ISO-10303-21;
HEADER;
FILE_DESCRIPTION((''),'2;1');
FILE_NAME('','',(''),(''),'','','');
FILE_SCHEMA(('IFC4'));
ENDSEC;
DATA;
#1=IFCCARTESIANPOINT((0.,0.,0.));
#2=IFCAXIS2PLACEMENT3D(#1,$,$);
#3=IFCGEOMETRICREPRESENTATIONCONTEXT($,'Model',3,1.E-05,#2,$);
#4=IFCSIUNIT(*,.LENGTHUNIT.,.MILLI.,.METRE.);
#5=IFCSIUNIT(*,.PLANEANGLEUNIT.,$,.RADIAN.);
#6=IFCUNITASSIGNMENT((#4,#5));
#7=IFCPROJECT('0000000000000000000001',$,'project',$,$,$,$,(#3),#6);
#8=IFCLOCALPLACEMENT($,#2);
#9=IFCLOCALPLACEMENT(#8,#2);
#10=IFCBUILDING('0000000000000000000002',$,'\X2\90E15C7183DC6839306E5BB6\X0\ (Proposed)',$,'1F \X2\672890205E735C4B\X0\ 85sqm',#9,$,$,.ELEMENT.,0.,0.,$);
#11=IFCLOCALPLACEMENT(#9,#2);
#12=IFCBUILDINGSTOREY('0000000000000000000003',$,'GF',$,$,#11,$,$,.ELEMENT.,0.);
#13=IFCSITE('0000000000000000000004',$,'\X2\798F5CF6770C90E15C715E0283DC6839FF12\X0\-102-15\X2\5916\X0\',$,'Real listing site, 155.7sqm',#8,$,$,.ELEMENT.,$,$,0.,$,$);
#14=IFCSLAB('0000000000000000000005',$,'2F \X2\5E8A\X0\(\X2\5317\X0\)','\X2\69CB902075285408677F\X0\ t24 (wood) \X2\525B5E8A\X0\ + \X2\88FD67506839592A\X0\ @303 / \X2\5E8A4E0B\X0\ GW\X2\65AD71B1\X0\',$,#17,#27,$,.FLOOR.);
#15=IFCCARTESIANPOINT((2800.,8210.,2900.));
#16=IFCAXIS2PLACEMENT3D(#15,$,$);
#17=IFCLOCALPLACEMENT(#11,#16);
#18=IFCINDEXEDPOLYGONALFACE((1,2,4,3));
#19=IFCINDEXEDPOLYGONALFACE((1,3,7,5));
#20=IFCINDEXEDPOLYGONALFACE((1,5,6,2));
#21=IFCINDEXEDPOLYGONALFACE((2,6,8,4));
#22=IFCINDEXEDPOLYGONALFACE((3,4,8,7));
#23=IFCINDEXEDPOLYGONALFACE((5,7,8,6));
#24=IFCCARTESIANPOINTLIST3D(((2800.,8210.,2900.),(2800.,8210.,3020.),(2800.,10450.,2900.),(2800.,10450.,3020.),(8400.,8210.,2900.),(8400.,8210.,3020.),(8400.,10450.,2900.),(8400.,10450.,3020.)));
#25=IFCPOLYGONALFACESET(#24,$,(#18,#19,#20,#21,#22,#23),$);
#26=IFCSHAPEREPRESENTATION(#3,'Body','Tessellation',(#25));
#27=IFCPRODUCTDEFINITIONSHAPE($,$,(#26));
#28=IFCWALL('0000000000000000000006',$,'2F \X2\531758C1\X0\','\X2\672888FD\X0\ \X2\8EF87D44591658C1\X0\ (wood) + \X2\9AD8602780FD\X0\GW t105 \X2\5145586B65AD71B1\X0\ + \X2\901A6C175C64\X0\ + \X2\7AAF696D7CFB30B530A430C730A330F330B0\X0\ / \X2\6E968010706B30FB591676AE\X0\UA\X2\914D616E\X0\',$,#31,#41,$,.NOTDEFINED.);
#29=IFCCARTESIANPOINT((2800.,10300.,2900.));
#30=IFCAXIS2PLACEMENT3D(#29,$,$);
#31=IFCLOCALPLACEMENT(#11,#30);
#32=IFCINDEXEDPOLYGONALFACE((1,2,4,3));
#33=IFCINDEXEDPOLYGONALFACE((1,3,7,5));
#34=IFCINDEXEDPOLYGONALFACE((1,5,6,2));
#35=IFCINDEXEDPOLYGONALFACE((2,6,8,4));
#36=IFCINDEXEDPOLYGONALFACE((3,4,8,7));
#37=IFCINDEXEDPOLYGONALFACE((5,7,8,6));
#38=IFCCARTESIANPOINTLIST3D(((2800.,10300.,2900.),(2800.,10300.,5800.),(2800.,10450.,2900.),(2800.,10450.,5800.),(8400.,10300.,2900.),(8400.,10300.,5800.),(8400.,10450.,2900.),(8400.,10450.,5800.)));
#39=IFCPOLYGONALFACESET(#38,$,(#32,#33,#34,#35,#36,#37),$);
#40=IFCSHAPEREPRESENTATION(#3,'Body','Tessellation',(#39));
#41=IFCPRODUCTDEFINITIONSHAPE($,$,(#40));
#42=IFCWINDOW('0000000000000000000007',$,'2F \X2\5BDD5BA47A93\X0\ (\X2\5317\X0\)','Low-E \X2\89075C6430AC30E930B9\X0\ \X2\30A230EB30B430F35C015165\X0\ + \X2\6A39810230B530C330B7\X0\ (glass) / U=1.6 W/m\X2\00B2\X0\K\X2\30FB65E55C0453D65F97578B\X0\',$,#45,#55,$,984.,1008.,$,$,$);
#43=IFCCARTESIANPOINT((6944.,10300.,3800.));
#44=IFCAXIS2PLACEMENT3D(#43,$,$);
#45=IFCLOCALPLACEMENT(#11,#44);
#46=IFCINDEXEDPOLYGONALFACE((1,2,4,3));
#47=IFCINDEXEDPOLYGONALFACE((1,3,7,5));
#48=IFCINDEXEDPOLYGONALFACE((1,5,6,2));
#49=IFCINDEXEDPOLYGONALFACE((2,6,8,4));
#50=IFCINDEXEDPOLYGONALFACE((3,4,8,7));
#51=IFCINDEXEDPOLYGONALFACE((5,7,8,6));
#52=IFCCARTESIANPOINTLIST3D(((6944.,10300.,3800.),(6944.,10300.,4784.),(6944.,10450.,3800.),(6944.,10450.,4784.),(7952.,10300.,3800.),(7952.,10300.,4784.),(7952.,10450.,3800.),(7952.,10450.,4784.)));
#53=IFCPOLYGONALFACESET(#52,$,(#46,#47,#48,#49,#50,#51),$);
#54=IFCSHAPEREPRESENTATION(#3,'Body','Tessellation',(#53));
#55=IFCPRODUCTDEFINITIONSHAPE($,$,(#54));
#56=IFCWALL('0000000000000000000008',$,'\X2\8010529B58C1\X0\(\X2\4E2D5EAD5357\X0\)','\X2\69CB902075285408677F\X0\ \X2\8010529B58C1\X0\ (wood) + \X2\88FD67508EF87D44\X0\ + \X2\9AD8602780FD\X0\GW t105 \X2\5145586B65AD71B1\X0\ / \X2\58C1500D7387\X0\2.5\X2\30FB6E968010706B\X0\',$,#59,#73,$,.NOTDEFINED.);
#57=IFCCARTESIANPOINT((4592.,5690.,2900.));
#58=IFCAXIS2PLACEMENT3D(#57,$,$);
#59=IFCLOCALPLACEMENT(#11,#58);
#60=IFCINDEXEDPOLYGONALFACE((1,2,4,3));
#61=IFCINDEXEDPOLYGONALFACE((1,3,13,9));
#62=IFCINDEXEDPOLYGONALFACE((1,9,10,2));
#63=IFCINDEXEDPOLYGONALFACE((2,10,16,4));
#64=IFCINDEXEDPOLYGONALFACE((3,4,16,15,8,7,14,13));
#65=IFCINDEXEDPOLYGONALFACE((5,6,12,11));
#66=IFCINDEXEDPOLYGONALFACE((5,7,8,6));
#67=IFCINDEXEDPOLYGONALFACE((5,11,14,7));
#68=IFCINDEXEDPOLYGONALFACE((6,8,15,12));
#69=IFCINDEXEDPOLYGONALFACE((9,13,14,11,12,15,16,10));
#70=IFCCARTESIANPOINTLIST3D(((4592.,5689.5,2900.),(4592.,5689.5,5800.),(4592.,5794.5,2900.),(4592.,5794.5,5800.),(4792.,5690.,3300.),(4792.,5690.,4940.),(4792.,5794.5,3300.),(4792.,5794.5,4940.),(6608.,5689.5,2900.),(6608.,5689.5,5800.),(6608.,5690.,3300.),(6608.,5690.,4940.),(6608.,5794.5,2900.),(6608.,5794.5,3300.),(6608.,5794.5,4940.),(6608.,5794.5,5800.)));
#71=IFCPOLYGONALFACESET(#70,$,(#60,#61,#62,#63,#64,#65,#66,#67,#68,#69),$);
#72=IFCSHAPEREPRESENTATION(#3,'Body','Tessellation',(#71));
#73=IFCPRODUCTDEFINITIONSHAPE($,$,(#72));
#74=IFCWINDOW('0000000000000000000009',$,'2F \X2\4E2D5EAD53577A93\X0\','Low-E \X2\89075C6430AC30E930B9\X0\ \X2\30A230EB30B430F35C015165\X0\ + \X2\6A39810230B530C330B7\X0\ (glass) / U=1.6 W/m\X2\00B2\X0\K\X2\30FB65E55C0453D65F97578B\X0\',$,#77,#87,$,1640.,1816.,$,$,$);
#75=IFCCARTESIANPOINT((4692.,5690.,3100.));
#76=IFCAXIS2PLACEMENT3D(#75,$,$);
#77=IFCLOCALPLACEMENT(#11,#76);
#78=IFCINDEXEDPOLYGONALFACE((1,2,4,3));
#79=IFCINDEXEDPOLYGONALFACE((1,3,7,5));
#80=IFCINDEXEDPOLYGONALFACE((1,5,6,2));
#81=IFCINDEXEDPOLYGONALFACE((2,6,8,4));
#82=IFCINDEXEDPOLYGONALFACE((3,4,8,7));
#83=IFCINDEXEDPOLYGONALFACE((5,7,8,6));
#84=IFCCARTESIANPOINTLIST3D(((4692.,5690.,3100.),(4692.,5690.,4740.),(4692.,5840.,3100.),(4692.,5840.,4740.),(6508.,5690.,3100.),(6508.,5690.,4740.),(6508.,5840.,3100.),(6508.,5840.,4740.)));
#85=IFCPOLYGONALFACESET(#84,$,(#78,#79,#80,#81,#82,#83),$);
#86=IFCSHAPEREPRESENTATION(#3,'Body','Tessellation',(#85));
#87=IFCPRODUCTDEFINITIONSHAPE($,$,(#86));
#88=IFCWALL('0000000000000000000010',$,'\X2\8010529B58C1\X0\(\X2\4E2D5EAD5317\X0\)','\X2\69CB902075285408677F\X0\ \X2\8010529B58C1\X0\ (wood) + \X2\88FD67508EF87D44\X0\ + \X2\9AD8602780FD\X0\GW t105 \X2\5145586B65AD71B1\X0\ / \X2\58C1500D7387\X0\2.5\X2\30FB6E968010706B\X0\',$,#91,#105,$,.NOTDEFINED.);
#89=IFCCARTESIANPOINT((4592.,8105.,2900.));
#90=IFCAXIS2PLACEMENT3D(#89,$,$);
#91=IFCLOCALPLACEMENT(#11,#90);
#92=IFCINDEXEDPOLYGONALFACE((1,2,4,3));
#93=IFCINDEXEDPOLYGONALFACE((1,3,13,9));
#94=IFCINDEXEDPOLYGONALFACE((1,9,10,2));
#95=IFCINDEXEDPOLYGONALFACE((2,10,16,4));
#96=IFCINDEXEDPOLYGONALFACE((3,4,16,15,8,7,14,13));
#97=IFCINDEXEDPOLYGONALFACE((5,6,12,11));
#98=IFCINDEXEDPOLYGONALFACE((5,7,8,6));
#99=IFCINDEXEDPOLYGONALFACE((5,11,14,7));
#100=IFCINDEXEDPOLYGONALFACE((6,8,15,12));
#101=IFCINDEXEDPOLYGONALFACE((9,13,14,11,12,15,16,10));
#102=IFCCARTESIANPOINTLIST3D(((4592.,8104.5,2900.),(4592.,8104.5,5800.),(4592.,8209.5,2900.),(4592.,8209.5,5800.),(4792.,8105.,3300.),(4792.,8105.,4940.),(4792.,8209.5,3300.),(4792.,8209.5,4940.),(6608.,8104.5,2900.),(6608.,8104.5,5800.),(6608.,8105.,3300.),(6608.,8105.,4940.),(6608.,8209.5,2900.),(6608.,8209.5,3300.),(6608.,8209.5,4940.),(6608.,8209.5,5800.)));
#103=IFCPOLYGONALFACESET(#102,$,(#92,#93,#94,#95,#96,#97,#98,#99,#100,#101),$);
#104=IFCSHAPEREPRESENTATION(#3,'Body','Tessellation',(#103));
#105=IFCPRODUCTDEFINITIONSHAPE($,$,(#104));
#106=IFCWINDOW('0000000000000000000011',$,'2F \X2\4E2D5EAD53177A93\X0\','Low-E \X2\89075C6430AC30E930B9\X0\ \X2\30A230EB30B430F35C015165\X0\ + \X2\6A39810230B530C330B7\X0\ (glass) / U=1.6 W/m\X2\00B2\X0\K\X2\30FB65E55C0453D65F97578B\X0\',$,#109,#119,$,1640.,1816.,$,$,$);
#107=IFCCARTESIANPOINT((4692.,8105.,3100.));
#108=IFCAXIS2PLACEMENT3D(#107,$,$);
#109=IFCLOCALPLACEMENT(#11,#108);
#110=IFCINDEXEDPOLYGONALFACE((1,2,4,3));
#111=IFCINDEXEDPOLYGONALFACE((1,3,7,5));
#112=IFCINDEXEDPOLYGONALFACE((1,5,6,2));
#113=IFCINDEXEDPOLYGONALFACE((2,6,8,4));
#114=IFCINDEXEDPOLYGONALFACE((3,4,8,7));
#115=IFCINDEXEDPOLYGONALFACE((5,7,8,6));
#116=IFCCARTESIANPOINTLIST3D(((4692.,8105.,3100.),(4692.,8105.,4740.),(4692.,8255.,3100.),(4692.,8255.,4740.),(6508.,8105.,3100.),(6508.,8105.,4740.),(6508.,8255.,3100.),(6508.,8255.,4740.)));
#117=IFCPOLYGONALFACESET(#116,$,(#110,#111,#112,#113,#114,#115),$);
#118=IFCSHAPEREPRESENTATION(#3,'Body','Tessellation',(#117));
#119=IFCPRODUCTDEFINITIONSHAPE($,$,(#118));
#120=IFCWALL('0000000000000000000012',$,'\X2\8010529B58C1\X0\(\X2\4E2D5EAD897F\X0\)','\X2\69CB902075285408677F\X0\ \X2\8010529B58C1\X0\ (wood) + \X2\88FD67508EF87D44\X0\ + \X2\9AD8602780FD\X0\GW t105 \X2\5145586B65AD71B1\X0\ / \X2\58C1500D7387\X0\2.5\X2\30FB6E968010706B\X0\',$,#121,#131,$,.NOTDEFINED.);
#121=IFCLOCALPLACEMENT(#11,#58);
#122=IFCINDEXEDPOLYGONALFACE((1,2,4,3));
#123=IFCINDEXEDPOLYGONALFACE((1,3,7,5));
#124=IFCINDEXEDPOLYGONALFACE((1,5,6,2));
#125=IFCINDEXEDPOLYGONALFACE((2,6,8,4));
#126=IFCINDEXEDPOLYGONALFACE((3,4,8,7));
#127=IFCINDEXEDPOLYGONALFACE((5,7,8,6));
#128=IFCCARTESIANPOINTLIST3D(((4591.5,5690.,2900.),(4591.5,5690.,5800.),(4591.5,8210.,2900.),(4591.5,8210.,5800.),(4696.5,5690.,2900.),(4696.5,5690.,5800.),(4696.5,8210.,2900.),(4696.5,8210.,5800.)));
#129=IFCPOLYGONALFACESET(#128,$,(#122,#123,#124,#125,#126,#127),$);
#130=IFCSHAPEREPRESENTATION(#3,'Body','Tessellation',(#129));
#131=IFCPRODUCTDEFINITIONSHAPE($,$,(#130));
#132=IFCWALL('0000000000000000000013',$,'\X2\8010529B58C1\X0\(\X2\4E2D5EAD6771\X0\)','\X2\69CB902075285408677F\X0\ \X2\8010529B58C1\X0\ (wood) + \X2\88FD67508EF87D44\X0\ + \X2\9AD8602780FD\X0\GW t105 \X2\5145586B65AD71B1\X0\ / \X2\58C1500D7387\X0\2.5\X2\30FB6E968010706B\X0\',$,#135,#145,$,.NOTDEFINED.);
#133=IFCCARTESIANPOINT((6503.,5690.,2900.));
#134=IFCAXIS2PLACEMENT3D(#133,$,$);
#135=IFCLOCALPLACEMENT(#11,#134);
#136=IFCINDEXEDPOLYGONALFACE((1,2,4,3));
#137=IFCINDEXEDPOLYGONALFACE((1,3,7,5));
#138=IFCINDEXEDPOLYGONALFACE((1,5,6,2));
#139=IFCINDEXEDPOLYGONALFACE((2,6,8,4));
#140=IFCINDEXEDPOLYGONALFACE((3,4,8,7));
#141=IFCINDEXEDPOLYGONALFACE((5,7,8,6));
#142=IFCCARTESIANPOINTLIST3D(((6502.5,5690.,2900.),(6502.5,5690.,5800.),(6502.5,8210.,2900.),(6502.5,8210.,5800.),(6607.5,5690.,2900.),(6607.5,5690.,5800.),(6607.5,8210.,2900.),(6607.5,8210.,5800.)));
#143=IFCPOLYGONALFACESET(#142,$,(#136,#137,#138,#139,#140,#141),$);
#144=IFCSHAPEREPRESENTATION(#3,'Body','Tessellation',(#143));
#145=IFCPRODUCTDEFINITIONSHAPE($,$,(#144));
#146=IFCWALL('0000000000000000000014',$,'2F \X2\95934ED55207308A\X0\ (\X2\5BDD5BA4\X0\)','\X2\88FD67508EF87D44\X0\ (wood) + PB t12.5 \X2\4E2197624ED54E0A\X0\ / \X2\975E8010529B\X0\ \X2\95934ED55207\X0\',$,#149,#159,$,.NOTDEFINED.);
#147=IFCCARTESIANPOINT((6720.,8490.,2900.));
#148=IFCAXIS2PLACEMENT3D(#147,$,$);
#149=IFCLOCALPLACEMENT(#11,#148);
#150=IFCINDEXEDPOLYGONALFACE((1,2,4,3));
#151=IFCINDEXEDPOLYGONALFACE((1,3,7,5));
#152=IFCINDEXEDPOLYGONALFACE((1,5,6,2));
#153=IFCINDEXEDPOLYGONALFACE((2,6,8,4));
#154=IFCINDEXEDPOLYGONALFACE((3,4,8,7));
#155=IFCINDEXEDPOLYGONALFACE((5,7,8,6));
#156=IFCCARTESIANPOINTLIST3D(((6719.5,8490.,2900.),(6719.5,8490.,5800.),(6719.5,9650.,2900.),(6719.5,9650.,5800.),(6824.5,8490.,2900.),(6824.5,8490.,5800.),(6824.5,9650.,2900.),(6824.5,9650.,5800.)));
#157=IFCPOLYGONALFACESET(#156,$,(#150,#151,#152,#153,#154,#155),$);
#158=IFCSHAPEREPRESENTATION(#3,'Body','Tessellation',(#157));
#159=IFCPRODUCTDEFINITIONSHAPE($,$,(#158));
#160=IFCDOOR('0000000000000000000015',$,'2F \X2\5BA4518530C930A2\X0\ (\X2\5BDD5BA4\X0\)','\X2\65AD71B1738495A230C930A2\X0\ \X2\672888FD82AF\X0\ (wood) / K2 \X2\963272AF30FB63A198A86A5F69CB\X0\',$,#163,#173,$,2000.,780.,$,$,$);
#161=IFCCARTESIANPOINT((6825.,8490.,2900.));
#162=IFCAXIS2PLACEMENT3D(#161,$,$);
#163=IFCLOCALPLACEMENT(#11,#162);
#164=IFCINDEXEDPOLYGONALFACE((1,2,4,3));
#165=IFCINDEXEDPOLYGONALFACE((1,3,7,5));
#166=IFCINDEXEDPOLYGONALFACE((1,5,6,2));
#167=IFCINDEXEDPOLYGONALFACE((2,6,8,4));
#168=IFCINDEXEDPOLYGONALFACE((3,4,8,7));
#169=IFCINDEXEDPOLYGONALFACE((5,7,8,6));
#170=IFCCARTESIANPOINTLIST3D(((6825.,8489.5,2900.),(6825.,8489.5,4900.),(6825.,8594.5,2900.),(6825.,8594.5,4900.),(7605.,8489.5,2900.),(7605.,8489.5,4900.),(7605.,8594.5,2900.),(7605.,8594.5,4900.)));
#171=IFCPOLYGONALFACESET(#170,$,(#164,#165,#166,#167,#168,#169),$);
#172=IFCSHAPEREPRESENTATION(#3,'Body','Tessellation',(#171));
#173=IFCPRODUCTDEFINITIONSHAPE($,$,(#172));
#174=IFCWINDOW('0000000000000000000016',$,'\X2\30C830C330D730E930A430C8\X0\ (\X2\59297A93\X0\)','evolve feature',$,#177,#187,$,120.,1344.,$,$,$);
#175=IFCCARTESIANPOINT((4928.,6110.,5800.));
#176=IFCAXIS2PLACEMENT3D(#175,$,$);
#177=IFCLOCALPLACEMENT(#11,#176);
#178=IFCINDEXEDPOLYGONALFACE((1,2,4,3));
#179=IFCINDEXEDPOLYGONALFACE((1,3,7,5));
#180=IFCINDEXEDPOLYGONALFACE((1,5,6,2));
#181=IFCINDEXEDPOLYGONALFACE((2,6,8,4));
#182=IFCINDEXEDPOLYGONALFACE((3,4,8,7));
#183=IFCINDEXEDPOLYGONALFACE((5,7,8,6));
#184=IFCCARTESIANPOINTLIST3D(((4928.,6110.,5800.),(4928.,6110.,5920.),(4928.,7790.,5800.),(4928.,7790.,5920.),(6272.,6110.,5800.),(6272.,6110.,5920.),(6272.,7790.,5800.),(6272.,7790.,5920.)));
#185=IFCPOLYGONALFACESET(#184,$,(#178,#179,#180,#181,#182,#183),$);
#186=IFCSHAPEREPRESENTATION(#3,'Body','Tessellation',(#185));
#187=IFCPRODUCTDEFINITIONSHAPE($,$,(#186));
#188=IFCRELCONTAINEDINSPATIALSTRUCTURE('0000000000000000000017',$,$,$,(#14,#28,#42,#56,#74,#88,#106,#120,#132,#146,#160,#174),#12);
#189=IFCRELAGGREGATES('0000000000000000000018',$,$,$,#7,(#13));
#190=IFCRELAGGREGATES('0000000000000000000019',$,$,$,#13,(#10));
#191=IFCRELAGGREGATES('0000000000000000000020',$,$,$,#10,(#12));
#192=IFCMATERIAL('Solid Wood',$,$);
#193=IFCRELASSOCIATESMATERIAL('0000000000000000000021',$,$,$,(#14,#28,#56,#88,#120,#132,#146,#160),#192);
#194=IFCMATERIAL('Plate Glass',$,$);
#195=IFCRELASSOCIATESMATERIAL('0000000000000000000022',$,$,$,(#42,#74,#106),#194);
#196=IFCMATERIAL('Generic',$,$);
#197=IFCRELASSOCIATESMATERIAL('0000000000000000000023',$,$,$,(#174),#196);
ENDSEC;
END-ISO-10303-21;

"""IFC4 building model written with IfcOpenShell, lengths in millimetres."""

from ifc_helpers import new_model, si_unit, frame, frame_2d, origin, place, context, project, spatial, rectangle, extrude, material, element, fill, save


model = new_model("IFC4")

# Units and contexts
model_context = context("Model", 3, precision=1e-05, world=origin())
ifc_project = project(units=[si_unit("LENGTHUNIT", "METRE", prefix="MILLI"), si_unit("PLANEANGLEUNIT", "RADIAN")], contexts=[model_context])

# Site, building, storey
site_placement = place(None, origin())
site = spatial("IfcSite", under=ifc_project, at=site_placement, Name="福島県郡山市菜根２-102-15外", ObjectType="Real listing site, 155.7sqm", CompositionType="ELEMENT", RefElevation=0.0)
building_placement = place(site_placement, origin())
building = spatial("IfcBuilding", under=site, at=building_placement, Name="郡山菜根の家 (Proposed)", ObjectType="1F 木造平屋 85sqm", CompositionType="ELEMENT", ElevationOfRefHeight=0.0, ElevationOfTerrain=0.0)
storey_placement = place(building_placement, origin())
storey = spatial("IfcBuildingStorey", under=building, at=storey_placement, Name="GF", CompositionType="ELEMENT", Elevation=0.0)

# Slab
ifc_material_1 = material(Name="Solid Wood")
slab_placement = place(storey_placement, frame((2800.0, 8210.0, 2900.0)))
element("IfcSlab", 1, at=slab_placement, inside=storey, material=ifc_material_1, Name="2F 床(北)", Description="構造用合板 t24 (wood) 剛床 + 製材根太 @303 / 床下 GW断熱", PredefinedType="FLOOR", context=model_context, shape_type="SweptSolid", body=[
    extrude(rectangle(XDim=5600.0, YDim=2240.0, at=frame_2d((2800.0, 1120.0))), frame((2800.0, 8210.0, 2900.0)), (0.0, 0.0, 1.0), 120.0),
])

# Walls, openings, windows
wall_1_placement = place(storey_placement, frame((2800.0, 10300.0, 2900.0)))
wall_1 = element("IfcWall", 2, at=wall_1_placement, inside=storey, material=ifc_material_1, Name="2F 北壁", Description="木製 軸組外壁 (wood) + 高性能GW t105 充填断熱 + 通気層 + 窯業系サイディング / 準耐火・外皮UA配慮", PredefinedType="NOTDEFINED", context=model_context, shape_type="SweptSolid", body=[
    extrude(rectangle(XDim=5600.0, YDim=150.0, at=frame_2d((2800.0, 75.0))), frame((2800.0, 10300.0, 2900.0)), (0.0, 0.0, 1.0), 2900.0),
])
opening_1_placement = place(storey_placement, frame((6944.0, 10300.0, 3800.0)))
opening_1 = element("IfcOpeningElement", 3, at=opening_1_placement, cuts=wall_1, PredefinedType="NOTDEFINED", context=model_context, shape_type="SweptSolid", body=[
    extrude(rectangle(XDim=1008.0, YDim=150.0, at=frame_2d((504.0, 75.0))), frame((6944.0, 10300.0, 3800.0)), (0.0, 0.0, 1.0), 984.0),
])
ifc_material_2 = material(Name="Plate Glass")
window_1_placement = place(storey_placement, frame((6944.0, 10300.0, 3800.0)))
window_1 = element("IfcWindow", 4, at=window_1_placement, inside=storey, material=ifc_material_2, Name="2F 寝室窓 (北)", Description="Low-E 複層ガラス アルゴン封入 + 樹脂サッシ (glass) / U=1.6 W/m²K・日射取得型", OverallHeight=984.0, OverallWidth=1008.0, context=model_context, shape_type="SweptSolid", body=[
    extrude(rectangle(XDim=1008.0, YDim=150.0, at=frame_2d((504.0, 75.0))), frame((6944.0, 10300.0, 3800.0)), (0.0, 0.0, 1.0), 984.0),
])
fill(opening_1, window_1)
wall_2_placement = place(storey_placement, frame((4592.0, 5690.0, 2900.0)))
wall_2 = element("IfcWall", 5, at=wall_2_placement, inside=storey, material=ifc_material_1, Name="耐力壁(中庭南)", Description="構造用合板 耐力壁 (wood) + 製材軸組 + 高性能GW t105 充填断熱 / 壁倍率2.5・準耐火", PredefinedType="NOTDEFINED", context=model_context, shape_type="SweptSolid", body=[
    extrude(rectangle(XDim=2016.0, YDim=105.0, at=frame_2d((1008.0, 52.0))), frame((4592.0, 5690.0, 2900.0)), (0.0, 0.0, 1.0), 2900.0),
])
opening_2_placement = place(storey_placement, frame((4692.0, 5690.0, 3100.0)))
opening_2 = element("IfcOpeningElement", 6, at=opening_2_placement, cuts=wall_2, PredefinedType="NOTDEFINED", context=model_context, shape_type="SweptSolid", body=[
    extrude(rectangle(XDim=1816.0, YDim=150.0, at=frame_2d((908.0, 75.0))), frame((4692.0, 5690.0, 3100.0)), (0.0, 0.0, 1.0), 1640.0),
])
window_2_placement = place(storey_placement, frame((4692.0, 5690.0, 3100.0)))
window_2 = element("IfcWindow", 7, at=window_2_placement, inside=storey, material=ifc_material_2, Name="2F 中庭南窓", Description="Low-E 複層ガラス アルゴン封入 + 樹脂サッシ (glass) / U=1.6 W/m²K・日射取得型", OverallHeight=1640.0, OverallWidth=1816.0, context=model_context, shape_type="SweptSolid", body=[
    extrude(rectangle(XDim=1816.0, YDim=150.0, at=frame_2d((908.0, 75.0))), frame((4692.0, 5690.0, 3100.0)), (0.0, 0.0, 1.0), 1640.0),
])
fill(opening_2, window_2)
wall_3_placement = place(storey_placement, frame((4592.0, 8105.0, 2900.0)))
wall_3 = element("IfcWall", 8, at=wall_3_placement, inside=storey, material=ifc_material_1, Name="耐力壁(中庭北)", Description="構造用合板 耐力壁 (wood) + 製材軸組 + 高性能GW t105 充填断熱 / 壁倍率2.5・準耐火", PredefinedType="NOTDEFINED", context=model_context, shape_type="SweptSolid", body=[
    extrude(rectangle(XDim=2016.0, YDim=105.0, at=frame_2d((1008.0, 52.0))), frame((4592.0, 8105.0, 2900.0)), (0.0, 0.0, 1.0), 2900.0),
])
opening_3_placement = place(storey_placement, frame((4692.0, 8105.0, 3100.0)))
opening_3 = element("IfcOpeningElement", 9, at=opening_3_placement, cuts=wall_3, PredefinedType="NOTDEFINED", context=model_context, shape_type="SweptSolid", body=[
    extrude(rectangle(XDim=1816.0, YDim=150.0, at=frame_2d((908.0, 75.0))), frame((4692.0, 8105.0, 3100.0)), (0.0, 0.0, 1.0), 1640.0),
])
window_3_placement = place(storey_placement, frame((4692.0, 8105.0, 3100.0)))
window_3 = element("IfcWindow", 10, at=window_3_placement, inside=storey, material=ifc_material_2, Name="2F 中庭北窓", Description="Low-E 複層ガラス アルゴン封入 + 樹脂サッシ (glass) / U=1.6 W/m²K・日射取得型", OverallHeight=1640.0, OverallWidth=1816.0, context=model_context, shape_type="SweptSolid", body=[
    extrude(rectangle(XDim=1816.0, YDim=150.0, at=frame_2d((908.0, 75.0))), frame((4692.0, 8105.0, 3100.0)), (0.0, 0.0, 1.0), 1640.0),
])
fill(opening_3, window_3)

# Walls
wall_4_placement = place(storey_placement, frame((4592.0, 5690.0, 2900.0)))
element("IfcWall", 11, at=wall_4_placement, inside=storey, material=ifc_material_1, Name="耐力壁(中庭西)", Description="構造用合板 耐力壁 (wood) + 製材軸組 + 高性能GW t105 充填断熱 / 壁倍率2.5・準耐火", PredefinedType="NOTDEFINED", context=model_context, shape_type="SweptSolid", body=[
    extrude(rectangle(XDim=105.0, YDim=2520.0, at=frame_2d((52.0, 1260.0))), frame((4592.0, 5690.0, 2900.0)), (0.0, 0.0, 1.0), 2900.0),
])
wall_5_placement = place(storey_placement, frame((6503.0, 5690.0, 2900.0)))
element("IfcWall", 12, at=wall_5_placement, inside=storey, material=ifc_material_1, Name="耐力壁(中庭東)", Description="構造用合板 耐力壁 (wood) + 製材軸組 + 高性能GW t105 充填断熱 / 壁倍率2.5・準耐火", PredefinedType="NOTDEFINED", context=model_context, shape_type="SweptSolid", body=[
    extrude(rectangle(XDim=105.0, YDim=2520.0, at=frame_2d((52.0, 1260.0))), frame((6503.0, 5690.0, 2900.0)), (0.0, 0.0, 1.0), 2900.0),
])
wall_6_placement = place(storey_placement, frame((6720.0, 8490.0, 2900.0)))
element("IfcWall", 13, at=wall_6_placement, inside=storey, material=ifc_material_1, Name="2F 間仕切り (寝室)", Description="製材軸組 (wood) + PB t12.5 両面仕上 / 非耐力 間仕切", PredefinedType="NOTDEFINED", context=model_context, shape_type="SweptSolid", body=[
    extrude(rectangle(XDim=105.0, YDim=1160.0, at=frame_2d((52.0, 580.0))), frame((6720.0, 8490.0, 2900.0)), (0.0, 0.0, 1.0), 2900.0),
])

# Door
door_placement = place(storey_placement, frame((6825.0, 8490.0, 2900.0)))
element("IfcDoor", 14, at=door_placement, inside=storey, material=ifc_material_1, Name="2F 室内ドア (寝室)", Description="断熱玄関ドア 木製芯 (wood) / K2 防犯・採風機構", OverallHeight=2000.0, OverallWidth=780.0, context=model_context, shape_type="SweptSolid", body=[
    extrude(rectangle(XDim=780.0, YDim=105.0, at=frame_2d((390.0, 52.0))), frame((6825.0, 8490.0, 2900.0)), (0.0, 0.0, 1.0), 2000.0),
])

# Window
ifc_material_3 = material(Name="Generic")
window_4_placement = place(storey_placement, frame((4928.0, 6110.0, 5800.0)))
element("IfcWindow", 15, at=window_4_placement, inside=storey, material=ifc_material_3, Name="トップライト (天窓)", Description="evolve feature", OverallHeight=120.0, OverallWidth=1344.0, context=model_context, shape_type="SweptSolid", body=[
    extrude(rectangle(XDim=1344.0, YDim=1680.0, at=frame_2d((672.0, 840.0))), frame((4928.0, 6110.0, 5800.0)), (0.0, 0.0, 1.0), 120.0),
])

save(model, "model.ifc")
